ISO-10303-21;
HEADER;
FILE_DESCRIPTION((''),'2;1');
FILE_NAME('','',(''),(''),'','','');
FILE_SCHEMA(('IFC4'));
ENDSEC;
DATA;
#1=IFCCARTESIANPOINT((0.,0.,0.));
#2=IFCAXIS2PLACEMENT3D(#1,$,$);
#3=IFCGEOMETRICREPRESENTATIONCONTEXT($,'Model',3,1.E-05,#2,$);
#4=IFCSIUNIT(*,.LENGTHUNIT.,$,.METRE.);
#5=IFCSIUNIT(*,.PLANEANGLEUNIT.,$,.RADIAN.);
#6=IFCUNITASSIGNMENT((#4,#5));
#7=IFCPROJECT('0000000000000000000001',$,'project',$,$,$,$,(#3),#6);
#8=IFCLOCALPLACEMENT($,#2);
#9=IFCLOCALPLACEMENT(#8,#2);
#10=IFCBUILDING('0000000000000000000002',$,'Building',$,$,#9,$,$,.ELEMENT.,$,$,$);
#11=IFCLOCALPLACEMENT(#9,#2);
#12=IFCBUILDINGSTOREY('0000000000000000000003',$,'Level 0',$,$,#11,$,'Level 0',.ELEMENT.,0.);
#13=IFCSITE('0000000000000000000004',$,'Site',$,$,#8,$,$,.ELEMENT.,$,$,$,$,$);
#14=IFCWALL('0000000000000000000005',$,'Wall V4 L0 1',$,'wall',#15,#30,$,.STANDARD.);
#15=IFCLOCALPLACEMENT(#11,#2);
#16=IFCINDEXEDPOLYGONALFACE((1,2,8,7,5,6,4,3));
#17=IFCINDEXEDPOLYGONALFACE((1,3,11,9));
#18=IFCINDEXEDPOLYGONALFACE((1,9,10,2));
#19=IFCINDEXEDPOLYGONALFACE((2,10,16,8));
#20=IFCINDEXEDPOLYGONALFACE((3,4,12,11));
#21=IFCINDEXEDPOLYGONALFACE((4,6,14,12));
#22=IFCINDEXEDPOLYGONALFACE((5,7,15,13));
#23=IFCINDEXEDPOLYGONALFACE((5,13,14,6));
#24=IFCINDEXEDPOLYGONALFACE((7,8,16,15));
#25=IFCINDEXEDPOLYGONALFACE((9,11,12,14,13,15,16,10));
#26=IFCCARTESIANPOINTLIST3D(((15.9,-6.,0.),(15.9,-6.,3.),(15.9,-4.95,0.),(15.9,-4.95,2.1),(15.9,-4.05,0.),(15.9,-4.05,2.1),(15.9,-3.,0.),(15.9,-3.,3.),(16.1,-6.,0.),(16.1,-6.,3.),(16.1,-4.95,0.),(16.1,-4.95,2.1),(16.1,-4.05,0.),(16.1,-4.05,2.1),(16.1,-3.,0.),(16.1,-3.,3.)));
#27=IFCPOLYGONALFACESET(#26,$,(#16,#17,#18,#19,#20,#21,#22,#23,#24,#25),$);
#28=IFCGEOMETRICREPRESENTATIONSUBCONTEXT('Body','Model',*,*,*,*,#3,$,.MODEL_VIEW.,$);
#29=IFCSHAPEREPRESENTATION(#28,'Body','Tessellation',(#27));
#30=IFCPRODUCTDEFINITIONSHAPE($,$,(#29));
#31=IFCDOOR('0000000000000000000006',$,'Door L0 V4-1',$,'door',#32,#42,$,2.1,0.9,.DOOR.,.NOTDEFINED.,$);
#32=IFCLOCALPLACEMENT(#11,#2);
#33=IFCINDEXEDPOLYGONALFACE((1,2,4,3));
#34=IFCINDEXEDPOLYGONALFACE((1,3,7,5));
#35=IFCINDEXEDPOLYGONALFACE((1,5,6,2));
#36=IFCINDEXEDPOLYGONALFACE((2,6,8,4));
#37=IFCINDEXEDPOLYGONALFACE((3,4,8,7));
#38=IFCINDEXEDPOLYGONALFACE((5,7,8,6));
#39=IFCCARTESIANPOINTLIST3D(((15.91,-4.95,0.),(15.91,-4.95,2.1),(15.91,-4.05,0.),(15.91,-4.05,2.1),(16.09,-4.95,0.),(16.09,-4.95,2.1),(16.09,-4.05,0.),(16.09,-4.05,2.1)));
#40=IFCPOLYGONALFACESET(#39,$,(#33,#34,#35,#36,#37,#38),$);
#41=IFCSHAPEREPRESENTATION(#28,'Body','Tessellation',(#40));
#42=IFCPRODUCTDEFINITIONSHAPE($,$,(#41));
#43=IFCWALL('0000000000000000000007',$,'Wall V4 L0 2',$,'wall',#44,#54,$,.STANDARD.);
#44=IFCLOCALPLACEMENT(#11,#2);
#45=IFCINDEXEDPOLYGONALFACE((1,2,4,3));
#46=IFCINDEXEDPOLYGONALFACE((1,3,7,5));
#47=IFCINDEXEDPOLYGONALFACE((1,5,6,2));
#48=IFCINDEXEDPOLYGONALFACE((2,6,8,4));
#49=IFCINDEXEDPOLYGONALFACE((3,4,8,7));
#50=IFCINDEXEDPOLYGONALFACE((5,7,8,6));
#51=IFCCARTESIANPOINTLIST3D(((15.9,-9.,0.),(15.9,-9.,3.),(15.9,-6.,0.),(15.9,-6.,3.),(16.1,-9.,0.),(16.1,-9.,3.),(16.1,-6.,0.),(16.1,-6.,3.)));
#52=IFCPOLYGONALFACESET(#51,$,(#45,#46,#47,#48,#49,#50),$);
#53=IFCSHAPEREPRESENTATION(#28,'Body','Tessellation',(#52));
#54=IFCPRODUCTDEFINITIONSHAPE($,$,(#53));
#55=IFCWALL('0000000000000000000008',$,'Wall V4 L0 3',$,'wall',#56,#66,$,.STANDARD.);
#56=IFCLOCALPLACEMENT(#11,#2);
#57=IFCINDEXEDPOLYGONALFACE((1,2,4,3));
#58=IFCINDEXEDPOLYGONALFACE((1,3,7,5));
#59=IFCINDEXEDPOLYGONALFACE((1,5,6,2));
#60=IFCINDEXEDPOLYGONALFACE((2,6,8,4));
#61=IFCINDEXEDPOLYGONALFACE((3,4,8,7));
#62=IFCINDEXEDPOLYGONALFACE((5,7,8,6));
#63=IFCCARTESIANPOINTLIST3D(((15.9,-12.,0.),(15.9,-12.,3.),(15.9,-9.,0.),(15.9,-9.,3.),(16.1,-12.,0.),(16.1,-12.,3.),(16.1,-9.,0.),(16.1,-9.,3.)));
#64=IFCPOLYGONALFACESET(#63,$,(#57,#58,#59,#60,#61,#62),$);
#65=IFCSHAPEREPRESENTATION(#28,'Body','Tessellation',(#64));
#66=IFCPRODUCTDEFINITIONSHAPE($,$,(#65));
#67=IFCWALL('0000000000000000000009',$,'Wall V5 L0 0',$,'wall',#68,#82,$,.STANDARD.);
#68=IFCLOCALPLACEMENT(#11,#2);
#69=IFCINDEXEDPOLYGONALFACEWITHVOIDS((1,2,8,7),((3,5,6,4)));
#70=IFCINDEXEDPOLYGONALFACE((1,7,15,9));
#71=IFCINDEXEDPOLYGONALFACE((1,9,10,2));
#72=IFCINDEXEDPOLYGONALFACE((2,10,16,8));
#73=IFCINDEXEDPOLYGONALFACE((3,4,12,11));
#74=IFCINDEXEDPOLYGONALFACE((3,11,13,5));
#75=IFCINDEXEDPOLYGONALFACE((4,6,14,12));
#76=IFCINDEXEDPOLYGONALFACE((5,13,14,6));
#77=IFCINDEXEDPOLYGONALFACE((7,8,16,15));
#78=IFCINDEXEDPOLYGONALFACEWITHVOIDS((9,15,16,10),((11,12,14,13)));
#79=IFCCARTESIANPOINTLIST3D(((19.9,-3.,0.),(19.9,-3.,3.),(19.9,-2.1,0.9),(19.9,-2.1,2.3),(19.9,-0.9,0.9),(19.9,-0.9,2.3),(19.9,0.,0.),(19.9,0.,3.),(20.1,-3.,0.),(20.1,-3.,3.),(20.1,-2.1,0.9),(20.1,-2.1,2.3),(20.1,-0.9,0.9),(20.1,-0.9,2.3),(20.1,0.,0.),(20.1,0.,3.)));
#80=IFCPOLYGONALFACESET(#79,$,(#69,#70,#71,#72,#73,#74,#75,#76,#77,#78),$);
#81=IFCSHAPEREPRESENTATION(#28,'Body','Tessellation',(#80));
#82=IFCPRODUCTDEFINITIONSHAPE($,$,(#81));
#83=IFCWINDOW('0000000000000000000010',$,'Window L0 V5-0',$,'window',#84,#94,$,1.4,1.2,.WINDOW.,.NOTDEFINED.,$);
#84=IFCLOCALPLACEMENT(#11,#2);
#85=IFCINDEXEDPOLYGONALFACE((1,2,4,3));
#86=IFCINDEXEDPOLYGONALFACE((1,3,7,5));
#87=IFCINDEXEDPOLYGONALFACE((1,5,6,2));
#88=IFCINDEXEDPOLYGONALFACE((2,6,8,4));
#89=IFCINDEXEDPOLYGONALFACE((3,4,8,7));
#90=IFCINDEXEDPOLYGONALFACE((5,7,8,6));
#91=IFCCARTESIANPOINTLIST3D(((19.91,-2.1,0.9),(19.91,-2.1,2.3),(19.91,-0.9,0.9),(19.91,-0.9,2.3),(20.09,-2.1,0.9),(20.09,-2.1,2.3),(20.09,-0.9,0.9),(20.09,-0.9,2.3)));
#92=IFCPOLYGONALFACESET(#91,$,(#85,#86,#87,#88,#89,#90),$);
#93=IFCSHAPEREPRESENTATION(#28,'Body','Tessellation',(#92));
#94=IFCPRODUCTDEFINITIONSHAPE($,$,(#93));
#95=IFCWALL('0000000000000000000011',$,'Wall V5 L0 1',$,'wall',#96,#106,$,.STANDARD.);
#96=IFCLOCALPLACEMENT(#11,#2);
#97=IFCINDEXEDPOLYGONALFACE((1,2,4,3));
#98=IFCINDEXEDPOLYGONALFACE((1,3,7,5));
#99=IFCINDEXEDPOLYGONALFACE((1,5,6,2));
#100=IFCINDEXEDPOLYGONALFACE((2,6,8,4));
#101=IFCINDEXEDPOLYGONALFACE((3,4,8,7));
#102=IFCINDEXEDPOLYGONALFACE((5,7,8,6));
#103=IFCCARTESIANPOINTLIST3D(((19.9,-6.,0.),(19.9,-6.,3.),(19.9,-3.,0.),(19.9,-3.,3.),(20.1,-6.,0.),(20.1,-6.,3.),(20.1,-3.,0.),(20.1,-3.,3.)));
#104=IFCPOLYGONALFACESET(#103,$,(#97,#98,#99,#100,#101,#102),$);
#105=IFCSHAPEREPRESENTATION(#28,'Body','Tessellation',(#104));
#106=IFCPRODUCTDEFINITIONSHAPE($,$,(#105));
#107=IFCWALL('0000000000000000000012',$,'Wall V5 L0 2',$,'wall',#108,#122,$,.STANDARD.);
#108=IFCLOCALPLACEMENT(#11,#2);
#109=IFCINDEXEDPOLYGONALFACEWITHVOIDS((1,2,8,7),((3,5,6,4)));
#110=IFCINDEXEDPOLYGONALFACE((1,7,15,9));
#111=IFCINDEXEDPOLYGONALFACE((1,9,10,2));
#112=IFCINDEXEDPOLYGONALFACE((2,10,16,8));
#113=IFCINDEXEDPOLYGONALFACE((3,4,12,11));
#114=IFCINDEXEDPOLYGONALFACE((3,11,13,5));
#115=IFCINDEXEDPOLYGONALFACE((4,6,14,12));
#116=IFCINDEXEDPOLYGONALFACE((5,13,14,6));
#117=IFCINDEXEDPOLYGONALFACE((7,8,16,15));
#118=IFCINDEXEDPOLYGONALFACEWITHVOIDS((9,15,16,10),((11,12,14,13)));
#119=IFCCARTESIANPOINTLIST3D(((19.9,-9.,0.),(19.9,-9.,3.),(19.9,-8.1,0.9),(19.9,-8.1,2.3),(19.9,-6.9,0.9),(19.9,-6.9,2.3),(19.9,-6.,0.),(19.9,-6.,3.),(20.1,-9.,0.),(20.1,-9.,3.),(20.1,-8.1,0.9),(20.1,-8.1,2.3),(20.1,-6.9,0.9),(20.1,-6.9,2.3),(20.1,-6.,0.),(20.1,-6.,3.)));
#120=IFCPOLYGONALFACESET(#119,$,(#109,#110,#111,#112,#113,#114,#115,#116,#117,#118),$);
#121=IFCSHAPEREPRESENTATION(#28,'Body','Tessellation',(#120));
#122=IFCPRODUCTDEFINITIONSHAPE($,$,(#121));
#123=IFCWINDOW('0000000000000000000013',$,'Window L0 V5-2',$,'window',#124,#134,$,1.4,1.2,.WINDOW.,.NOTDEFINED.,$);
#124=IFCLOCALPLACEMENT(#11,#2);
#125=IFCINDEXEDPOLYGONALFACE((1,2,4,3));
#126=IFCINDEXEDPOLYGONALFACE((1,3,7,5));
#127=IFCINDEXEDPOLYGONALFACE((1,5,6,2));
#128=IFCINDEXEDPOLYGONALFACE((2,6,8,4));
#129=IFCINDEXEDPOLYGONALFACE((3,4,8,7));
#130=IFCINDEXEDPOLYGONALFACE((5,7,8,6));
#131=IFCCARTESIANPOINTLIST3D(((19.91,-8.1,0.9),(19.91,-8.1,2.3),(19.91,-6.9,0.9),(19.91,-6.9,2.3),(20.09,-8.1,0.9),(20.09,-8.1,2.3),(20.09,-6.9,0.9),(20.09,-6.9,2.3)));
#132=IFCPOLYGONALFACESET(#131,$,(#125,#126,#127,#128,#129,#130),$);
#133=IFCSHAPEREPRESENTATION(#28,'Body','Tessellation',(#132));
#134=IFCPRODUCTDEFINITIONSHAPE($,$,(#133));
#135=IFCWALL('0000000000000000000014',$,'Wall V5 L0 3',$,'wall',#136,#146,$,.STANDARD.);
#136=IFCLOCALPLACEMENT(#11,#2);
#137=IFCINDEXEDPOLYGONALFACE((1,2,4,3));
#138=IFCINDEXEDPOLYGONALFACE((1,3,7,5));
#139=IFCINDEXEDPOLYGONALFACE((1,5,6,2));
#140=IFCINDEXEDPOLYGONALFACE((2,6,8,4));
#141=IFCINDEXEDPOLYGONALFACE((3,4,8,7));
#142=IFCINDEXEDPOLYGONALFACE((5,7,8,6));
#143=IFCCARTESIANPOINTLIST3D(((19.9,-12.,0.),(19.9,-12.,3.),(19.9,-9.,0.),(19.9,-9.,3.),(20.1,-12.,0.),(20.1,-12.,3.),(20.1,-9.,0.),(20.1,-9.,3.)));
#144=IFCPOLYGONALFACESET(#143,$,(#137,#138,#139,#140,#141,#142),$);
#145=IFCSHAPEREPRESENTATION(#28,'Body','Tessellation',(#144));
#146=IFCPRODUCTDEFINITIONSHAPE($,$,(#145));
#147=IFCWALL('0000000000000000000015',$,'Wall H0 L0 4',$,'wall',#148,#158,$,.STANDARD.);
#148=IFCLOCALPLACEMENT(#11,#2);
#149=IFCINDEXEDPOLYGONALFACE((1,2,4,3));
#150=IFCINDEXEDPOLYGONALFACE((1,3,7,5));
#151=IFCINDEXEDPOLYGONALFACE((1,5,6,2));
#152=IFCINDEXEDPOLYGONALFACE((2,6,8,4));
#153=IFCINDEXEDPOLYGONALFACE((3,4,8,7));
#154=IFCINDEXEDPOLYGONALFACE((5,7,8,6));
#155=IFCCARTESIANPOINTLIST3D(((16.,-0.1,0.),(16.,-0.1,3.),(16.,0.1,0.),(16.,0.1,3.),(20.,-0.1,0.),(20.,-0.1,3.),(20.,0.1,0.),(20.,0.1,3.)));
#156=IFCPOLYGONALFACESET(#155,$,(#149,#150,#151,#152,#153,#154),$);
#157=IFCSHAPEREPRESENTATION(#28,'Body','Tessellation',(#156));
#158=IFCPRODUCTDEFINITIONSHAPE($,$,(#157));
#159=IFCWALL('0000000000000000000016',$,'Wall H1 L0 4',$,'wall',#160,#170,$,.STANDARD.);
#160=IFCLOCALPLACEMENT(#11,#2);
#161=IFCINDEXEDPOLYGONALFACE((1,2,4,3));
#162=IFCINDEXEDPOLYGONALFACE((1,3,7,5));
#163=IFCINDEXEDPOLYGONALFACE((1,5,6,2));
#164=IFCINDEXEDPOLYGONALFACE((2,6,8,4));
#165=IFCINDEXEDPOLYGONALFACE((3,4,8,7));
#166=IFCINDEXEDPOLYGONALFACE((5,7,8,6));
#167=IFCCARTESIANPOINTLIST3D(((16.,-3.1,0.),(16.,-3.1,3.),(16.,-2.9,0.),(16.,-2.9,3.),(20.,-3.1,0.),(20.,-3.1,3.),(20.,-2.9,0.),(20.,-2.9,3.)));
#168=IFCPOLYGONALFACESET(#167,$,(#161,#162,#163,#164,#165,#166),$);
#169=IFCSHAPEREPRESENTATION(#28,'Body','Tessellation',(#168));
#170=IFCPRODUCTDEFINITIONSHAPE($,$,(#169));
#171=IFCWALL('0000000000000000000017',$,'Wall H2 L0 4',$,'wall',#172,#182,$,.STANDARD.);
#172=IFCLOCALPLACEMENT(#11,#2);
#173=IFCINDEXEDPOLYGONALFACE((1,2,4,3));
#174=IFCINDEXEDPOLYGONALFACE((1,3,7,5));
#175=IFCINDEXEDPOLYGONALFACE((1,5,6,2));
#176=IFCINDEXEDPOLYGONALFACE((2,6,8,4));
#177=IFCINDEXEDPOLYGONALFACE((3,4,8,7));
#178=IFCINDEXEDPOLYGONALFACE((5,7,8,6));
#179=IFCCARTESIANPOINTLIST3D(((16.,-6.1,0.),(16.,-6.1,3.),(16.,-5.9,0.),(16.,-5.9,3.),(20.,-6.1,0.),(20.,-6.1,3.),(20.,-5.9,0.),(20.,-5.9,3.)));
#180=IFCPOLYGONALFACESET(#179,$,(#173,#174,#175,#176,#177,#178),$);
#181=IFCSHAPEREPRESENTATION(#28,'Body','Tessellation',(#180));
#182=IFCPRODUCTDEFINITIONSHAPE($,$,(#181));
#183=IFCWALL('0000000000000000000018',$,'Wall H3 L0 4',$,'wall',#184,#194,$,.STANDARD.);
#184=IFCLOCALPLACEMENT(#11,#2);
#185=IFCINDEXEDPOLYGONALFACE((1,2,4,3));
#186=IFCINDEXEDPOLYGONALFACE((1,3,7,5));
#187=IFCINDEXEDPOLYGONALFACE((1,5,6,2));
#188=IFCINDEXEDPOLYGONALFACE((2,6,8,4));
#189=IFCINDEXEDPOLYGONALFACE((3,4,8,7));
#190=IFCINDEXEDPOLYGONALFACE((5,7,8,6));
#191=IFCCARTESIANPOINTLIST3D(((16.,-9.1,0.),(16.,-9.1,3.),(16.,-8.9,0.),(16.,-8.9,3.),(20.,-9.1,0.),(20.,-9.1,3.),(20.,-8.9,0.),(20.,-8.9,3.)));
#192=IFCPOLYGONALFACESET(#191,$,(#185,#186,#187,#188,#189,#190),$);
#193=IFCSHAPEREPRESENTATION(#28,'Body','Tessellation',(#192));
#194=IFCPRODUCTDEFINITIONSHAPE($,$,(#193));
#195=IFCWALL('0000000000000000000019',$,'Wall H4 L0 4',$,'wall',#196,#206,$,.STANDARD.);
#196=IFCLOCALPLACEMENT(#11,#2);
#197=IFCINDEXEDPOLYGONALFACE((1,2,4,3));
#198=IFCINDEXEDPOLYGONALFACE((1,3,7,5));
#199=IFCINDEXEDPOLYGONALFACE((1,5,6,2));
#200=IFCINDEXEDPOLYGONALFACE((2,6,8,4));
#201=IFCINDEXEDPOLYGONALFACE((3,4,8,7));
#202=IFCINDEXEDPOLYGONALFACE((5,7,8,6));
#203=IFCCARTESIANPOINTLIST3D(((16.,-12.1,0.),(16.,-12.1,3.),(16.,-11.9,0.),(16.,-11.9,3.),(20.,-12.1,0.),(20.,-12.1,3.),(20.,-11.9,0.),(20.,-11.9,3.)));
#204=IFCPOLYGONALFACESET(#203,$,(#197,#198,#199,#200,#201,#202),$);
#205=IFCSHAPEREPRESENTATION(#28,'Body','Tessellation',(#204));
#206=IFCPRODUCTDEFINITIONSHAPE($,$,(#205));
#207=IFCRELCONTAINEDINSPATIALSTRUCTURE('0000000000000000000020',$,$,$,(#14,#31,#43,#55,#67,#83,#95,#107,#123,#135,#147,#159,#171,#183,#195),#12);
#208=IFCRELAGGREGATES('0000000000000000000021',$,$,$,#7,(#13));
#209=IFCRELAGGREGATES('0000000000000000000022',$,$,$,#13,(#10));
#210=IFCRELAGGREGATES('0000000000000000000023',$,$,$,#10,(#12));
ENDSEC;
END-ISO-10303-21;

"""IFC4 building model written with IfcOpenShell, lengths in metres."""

from ifc_helpers import new_model, si_unit, frame, frame_2d, origin, origin_2d, place, context, subcontext, project, spatial, rectangle, extrude, element, fill, save


model = new_model("IFC4")

# Units and contexts
model_context = context("Model", 3, precision=1e-05, world=origin())
body_context = subcontext(model_context, "Body", "Model", "MODEL_VIEW")
ifc_project = project(units=[si_unit("LENGTHUNIT", "METRE"), si_unit("PLANEANGLEUNIT", "RADIAN")], contexts=[model_context])

# Site, building, storey
site_placement = place(None, origin())
site = spatial("IfcSite", under=ifc_project, at=site_placement, Name="Site", CompositionType="ELEMENT")
building_placement = place(site_placement, origin())
building = spatial("IfcBuilding", under=site, at=building_placement, Name="Building", CompositionType="ELEMENT")
storey_placement = place(building_placement, origin())
storey = spatial("IfcBuildingStorey", under=building, at=storey_placement, Name="Level 0", LongName="Level 0", CompositionType="ELEMENT", Elevation=0.0)

# Wall, opening, door
wall_1_placement = place(storey_placement, frame((16.0, -3.0, 0.0), z_axis=(0.0, 0.0, 1.0), x_axis=(0.0, -1.0, 0.0)))
wall_1 = element("IfcWall", 1, at=wall_1_placement, inside=storey, Name="Wall V4 L0 1", ObjectType="wall", PredefinedType="STANDARD", context=body_context, shape_type="SweptSolid", body=[
    extrude(rectangle(XDim=3.0, YDim=0.2, at=frame_2d((1.5, 0.0))), origin(), (0.0, 0.0, 1.0), 3.0),
])
opening_1_placement = place(storey_placement, frame((16.0, -4.5, 0.0), z_axis=(0.0, 0.0, 1.0), x_axis=(0.0, -1.0, 0.0)))
opening_1 = element("IfcOpeningElement", 2, at=opening_1_placement, cuts=wall_1, ObjectType="Opening", PredefinedType="OPENING", context=body_context, shape_type="SweptSolid", body=[
    extrude(rectangle(XDim=0.9, YDim=0.22, at=origin_2d()), origin(), (0.0, 0.0, 1.0), 2.1),
])
door_placement = place(storey_placement, frame((16.0, -4.5, 0.0), z_axis=(0.0, 0.0, 1.0), x_axis=(0.0, -1.0, 0.0)))
door = element("IfcDoor", 3, at=door_placement, inside=storey, Name="Door L0 V4-1", ObjectType="door", OperationType="NOTDEFINED", OverallHeight=2.1, OverallWidth=0.9, PredefinedType="DOOR", context=body_context, shape_type="SweptSolid", body=[
    extrude(rectangle(XDim=0.9, YDim=0.18, at=origin_2d()), origin(), (0.0, 0.0, 1.0), 2.1),
])
fill(opening_1, door)

# Walls
for number, where, z_axis, x_axis, name in (
    (4, (16.0, -6.0, 0.0), (0.0, 0.0, 1.0), (0.0, -1.0, 0.0), "Wall V4 L0 2"),
    (5, (16.0, -9.0, 0.0), (0.0, 0.0, 1.0), (0.0, -1.0, 0.0), "Wall V4 L0 3"),
):
    element("IfcWall", number, at=place(storey_placement, frame(where, z_axis=z_axis, x_axis=x_axis)), inside=storey, Name=name, ObjectType="wall", PredefinedType="STANDARD", context=body_context, shape_type="SweptSolid", body=[
        extrude(rectangle(XDim=3.0, YDim=0.2, at=frame_2d((1.5, 0.0))), origin(), (0.0, 0.0, 1.0), 3.0),
    ])

# Wall, opening, window
wall_2_placement = place(storey_placement, frame((20.0, 0.0, 0.0), z_axis=(0.0, 0.0, 1.0), x_axis=(0.0, -1.0, 0.0)))
wall_2 = element("IfcWall", 6, at=wall_2_placement, inside=storey, Name="Wall V5 L0 0", ObjectType="wall", PredefinedType="STANDARD", context=body_context, shape_type="SweptSolid", body=[
    extrude(rectangle(XDim=3.0, YDim=0.2, at=frame_2d((1.5, 0.0))), origin(), (0.0, 0.0, 1.0), 3.0),
])
opening_2_placement = place(storey_placement, frame((20.0, -1.5, 0.9), z_axis=(0.0, 0.0, 1.0), x_axis=(0.0, -1.0, 0.0)))
opening_2 = element("IfcOpeningElement", 7, at=opening_2_placement, cuts=wall_2, ObjectType="Opening", PredefinedType="OPENING", context=body_context, shape_type="SweptSolid", body=[
    extrude(rectangle(XDim=1.2, YDim=0.22, at=origin_2d()), origin(), (0.0, 0.0, 1.0), 1.4),
])
window_1_placement = place(storey_placement, frame((20.0, -1.5, 0.9), z_axis=(0.0, 0.0, 1.0), x_axis=(0.0, -1.0, 0.0)))
window_1 = element("IfcWindow", 8, at=window_1_placement, inside=storey, Name="Window L0 V5-0", ObjectType="window", OverallHeight=1.4, OverallWidth=1.2, PartitioningType="NOTDEFINED", PredefinedType="WINDOW", context=body_context, shape_type="SweptSolid", body=[
    extrude(rectangle(XDim=1.2, YDim=0.18, at=origin_2d()), origin(), (0.0, 0.0, 1.0), 1.4),
])
fill(opening_2, window_1)

# Wall
wall_3_placement = place(storey_placement, frame((20.0, -3.0, 0.0), z_axis=(0.0, 0.0, 1.0), x_axis=(0.0, -1.0, 0.0)))
element("IfcWall", 9, at=wall_3_placement, inside=storey, Name="Wall V5 L0 1", ObjectType="wall", PredefinedType="STANDARD", context=body_context, shape_type="SweptSolid", body=[
    extrude(rectangle(XDim=3.0, YDim=0.2, at=frame_2d((1.5, 0.0))), origin(), (0.0, 0.0, 1.0), 3.0),
])

# Wall, opening, window
wall_4_placement = place(storey_placement, frame((20.0, -6.0, 0.0), z_axis=(0.0, 0.0, 1.0), x_axis=(0.0, -1.0, 0.0)))
wall_4 = element("IfcWall", 10, at=wall_4_placement, inside=storey, Name="Wall V5 L0 2", ObjectType="wall", PredefinedType="STANDARD", context=body_context, shape_type="SweptSolid", body=[
    extrude(rectangle(XDim=3.0, YDim=0.2, at=frame_2d((1.5, 0.0))), origin(), (0.0, 0.0, 1.0), 3.0),
])
opening_3_placement = place(storey_placement, frame((20.0, -7.5, 0.9), z_axis=(0.0, 0.0, 1.0), x_axis=(0.0, -1.0, 0.0)))
opening_3 = element("IfcOpeningElement", 11, at=opening_3_placement, cuts=wall_4, ObjectType="Opening", PredefinedType="OPENING", context=body_context, shape_type="SweptSolid", body=[
    extrude(rectangle(XDim=1.2, YDim=0.22, at=origin_2d()), origin(), (0.0, 0.0, 1.0), 1.4),
])
window_2_placement = place(storey_placement, frame((20.0, -7.5, 0.9), z_axis=(0.0, 0.0, 1.0), x_axis=(0.0, -1.0, 0.0)))
window_2 = element("IfcWindow", 12, at=window_2_placement, inside=storey, Name="Window L0 V5-2", ObjectType="window", OverallHeight=1.4, OverallWidth=1.2, PartitioningType="NOTDEFINED", PredefinedType="WINDOW", context=body_context, shape_type="SweptSolid", body=[
    extrude(rectangle(XDim=1.2, YDim=0.18, at=origin_2d()), origin(), (0.0, 0.0, 1.0), 1.4),
])
fill(opening_3, window_2)

# Walls
wall_5_placement = place(storey_placement, frame((20.0, -9.0, 0.0), z_axis=(0.0, 0.0, 1.0), x_axis=(0.0, -1.0, 0.0)))
element("IfcWall", 13, at=wall_5_placement, inside=storey, Name="Wall V5 L0 3", ObjectType="wall", PredefinedType="STANDARD", context=body_context, shape_type="SweptSolid", body=[
    extrude(rectangle(XDim=3.0, YDim=0.2, at=frame_2d((1.5, 0.0))), origin(), (0.0, 0.0, 1.0), 3.0),
])
for number, where, z_axis, x_axis, name in (
    (14, (16.0, 0.0, 0.0), (0.0, 0.0, 1.0), (1.0, 0.0, 0.0), "Wall H0 L0 4"),
    (15, (16.0, -3.0, 0.0), (0.0, 0.0, 1.0), (1.0, 0.0, 0.0), "Wall H1 L0 4"),
    (16, (16.0, -6.0, 0.0), (0.0, 0.0, 1.0), (1.0, 0.0, 0.0), "Wall H2 L0 4"),
    (17, (16.0, -9.0, 0.0), (0.0, 0.0, 1.0), (1.0, 0.0, 0.0), "Wall H3 L0 4"),
    (18, (16.0, -12.0, 0.0), (0.0, 0.0, 1.0), (1.0, 0.0, 0.0), "Wall H4 L0 4"),
):
    element("IfcWall", number, at=place(storey_placement, frame(where, z_axis=z_axis, x_axis=x_axis)), inside=storey, Name=name, ObjectType="wall", PredefinedType="STANDARD", context=body_context, shape_type="SweptSolid", body=[
        extrude(rectangle(XDim=4.0, YDim=0.2, at=frame_2d((2.0, 0.0))), origin(), (0.0, 0.0, 1.0), 3.0),
    ])

save(model, "model.ifc")
